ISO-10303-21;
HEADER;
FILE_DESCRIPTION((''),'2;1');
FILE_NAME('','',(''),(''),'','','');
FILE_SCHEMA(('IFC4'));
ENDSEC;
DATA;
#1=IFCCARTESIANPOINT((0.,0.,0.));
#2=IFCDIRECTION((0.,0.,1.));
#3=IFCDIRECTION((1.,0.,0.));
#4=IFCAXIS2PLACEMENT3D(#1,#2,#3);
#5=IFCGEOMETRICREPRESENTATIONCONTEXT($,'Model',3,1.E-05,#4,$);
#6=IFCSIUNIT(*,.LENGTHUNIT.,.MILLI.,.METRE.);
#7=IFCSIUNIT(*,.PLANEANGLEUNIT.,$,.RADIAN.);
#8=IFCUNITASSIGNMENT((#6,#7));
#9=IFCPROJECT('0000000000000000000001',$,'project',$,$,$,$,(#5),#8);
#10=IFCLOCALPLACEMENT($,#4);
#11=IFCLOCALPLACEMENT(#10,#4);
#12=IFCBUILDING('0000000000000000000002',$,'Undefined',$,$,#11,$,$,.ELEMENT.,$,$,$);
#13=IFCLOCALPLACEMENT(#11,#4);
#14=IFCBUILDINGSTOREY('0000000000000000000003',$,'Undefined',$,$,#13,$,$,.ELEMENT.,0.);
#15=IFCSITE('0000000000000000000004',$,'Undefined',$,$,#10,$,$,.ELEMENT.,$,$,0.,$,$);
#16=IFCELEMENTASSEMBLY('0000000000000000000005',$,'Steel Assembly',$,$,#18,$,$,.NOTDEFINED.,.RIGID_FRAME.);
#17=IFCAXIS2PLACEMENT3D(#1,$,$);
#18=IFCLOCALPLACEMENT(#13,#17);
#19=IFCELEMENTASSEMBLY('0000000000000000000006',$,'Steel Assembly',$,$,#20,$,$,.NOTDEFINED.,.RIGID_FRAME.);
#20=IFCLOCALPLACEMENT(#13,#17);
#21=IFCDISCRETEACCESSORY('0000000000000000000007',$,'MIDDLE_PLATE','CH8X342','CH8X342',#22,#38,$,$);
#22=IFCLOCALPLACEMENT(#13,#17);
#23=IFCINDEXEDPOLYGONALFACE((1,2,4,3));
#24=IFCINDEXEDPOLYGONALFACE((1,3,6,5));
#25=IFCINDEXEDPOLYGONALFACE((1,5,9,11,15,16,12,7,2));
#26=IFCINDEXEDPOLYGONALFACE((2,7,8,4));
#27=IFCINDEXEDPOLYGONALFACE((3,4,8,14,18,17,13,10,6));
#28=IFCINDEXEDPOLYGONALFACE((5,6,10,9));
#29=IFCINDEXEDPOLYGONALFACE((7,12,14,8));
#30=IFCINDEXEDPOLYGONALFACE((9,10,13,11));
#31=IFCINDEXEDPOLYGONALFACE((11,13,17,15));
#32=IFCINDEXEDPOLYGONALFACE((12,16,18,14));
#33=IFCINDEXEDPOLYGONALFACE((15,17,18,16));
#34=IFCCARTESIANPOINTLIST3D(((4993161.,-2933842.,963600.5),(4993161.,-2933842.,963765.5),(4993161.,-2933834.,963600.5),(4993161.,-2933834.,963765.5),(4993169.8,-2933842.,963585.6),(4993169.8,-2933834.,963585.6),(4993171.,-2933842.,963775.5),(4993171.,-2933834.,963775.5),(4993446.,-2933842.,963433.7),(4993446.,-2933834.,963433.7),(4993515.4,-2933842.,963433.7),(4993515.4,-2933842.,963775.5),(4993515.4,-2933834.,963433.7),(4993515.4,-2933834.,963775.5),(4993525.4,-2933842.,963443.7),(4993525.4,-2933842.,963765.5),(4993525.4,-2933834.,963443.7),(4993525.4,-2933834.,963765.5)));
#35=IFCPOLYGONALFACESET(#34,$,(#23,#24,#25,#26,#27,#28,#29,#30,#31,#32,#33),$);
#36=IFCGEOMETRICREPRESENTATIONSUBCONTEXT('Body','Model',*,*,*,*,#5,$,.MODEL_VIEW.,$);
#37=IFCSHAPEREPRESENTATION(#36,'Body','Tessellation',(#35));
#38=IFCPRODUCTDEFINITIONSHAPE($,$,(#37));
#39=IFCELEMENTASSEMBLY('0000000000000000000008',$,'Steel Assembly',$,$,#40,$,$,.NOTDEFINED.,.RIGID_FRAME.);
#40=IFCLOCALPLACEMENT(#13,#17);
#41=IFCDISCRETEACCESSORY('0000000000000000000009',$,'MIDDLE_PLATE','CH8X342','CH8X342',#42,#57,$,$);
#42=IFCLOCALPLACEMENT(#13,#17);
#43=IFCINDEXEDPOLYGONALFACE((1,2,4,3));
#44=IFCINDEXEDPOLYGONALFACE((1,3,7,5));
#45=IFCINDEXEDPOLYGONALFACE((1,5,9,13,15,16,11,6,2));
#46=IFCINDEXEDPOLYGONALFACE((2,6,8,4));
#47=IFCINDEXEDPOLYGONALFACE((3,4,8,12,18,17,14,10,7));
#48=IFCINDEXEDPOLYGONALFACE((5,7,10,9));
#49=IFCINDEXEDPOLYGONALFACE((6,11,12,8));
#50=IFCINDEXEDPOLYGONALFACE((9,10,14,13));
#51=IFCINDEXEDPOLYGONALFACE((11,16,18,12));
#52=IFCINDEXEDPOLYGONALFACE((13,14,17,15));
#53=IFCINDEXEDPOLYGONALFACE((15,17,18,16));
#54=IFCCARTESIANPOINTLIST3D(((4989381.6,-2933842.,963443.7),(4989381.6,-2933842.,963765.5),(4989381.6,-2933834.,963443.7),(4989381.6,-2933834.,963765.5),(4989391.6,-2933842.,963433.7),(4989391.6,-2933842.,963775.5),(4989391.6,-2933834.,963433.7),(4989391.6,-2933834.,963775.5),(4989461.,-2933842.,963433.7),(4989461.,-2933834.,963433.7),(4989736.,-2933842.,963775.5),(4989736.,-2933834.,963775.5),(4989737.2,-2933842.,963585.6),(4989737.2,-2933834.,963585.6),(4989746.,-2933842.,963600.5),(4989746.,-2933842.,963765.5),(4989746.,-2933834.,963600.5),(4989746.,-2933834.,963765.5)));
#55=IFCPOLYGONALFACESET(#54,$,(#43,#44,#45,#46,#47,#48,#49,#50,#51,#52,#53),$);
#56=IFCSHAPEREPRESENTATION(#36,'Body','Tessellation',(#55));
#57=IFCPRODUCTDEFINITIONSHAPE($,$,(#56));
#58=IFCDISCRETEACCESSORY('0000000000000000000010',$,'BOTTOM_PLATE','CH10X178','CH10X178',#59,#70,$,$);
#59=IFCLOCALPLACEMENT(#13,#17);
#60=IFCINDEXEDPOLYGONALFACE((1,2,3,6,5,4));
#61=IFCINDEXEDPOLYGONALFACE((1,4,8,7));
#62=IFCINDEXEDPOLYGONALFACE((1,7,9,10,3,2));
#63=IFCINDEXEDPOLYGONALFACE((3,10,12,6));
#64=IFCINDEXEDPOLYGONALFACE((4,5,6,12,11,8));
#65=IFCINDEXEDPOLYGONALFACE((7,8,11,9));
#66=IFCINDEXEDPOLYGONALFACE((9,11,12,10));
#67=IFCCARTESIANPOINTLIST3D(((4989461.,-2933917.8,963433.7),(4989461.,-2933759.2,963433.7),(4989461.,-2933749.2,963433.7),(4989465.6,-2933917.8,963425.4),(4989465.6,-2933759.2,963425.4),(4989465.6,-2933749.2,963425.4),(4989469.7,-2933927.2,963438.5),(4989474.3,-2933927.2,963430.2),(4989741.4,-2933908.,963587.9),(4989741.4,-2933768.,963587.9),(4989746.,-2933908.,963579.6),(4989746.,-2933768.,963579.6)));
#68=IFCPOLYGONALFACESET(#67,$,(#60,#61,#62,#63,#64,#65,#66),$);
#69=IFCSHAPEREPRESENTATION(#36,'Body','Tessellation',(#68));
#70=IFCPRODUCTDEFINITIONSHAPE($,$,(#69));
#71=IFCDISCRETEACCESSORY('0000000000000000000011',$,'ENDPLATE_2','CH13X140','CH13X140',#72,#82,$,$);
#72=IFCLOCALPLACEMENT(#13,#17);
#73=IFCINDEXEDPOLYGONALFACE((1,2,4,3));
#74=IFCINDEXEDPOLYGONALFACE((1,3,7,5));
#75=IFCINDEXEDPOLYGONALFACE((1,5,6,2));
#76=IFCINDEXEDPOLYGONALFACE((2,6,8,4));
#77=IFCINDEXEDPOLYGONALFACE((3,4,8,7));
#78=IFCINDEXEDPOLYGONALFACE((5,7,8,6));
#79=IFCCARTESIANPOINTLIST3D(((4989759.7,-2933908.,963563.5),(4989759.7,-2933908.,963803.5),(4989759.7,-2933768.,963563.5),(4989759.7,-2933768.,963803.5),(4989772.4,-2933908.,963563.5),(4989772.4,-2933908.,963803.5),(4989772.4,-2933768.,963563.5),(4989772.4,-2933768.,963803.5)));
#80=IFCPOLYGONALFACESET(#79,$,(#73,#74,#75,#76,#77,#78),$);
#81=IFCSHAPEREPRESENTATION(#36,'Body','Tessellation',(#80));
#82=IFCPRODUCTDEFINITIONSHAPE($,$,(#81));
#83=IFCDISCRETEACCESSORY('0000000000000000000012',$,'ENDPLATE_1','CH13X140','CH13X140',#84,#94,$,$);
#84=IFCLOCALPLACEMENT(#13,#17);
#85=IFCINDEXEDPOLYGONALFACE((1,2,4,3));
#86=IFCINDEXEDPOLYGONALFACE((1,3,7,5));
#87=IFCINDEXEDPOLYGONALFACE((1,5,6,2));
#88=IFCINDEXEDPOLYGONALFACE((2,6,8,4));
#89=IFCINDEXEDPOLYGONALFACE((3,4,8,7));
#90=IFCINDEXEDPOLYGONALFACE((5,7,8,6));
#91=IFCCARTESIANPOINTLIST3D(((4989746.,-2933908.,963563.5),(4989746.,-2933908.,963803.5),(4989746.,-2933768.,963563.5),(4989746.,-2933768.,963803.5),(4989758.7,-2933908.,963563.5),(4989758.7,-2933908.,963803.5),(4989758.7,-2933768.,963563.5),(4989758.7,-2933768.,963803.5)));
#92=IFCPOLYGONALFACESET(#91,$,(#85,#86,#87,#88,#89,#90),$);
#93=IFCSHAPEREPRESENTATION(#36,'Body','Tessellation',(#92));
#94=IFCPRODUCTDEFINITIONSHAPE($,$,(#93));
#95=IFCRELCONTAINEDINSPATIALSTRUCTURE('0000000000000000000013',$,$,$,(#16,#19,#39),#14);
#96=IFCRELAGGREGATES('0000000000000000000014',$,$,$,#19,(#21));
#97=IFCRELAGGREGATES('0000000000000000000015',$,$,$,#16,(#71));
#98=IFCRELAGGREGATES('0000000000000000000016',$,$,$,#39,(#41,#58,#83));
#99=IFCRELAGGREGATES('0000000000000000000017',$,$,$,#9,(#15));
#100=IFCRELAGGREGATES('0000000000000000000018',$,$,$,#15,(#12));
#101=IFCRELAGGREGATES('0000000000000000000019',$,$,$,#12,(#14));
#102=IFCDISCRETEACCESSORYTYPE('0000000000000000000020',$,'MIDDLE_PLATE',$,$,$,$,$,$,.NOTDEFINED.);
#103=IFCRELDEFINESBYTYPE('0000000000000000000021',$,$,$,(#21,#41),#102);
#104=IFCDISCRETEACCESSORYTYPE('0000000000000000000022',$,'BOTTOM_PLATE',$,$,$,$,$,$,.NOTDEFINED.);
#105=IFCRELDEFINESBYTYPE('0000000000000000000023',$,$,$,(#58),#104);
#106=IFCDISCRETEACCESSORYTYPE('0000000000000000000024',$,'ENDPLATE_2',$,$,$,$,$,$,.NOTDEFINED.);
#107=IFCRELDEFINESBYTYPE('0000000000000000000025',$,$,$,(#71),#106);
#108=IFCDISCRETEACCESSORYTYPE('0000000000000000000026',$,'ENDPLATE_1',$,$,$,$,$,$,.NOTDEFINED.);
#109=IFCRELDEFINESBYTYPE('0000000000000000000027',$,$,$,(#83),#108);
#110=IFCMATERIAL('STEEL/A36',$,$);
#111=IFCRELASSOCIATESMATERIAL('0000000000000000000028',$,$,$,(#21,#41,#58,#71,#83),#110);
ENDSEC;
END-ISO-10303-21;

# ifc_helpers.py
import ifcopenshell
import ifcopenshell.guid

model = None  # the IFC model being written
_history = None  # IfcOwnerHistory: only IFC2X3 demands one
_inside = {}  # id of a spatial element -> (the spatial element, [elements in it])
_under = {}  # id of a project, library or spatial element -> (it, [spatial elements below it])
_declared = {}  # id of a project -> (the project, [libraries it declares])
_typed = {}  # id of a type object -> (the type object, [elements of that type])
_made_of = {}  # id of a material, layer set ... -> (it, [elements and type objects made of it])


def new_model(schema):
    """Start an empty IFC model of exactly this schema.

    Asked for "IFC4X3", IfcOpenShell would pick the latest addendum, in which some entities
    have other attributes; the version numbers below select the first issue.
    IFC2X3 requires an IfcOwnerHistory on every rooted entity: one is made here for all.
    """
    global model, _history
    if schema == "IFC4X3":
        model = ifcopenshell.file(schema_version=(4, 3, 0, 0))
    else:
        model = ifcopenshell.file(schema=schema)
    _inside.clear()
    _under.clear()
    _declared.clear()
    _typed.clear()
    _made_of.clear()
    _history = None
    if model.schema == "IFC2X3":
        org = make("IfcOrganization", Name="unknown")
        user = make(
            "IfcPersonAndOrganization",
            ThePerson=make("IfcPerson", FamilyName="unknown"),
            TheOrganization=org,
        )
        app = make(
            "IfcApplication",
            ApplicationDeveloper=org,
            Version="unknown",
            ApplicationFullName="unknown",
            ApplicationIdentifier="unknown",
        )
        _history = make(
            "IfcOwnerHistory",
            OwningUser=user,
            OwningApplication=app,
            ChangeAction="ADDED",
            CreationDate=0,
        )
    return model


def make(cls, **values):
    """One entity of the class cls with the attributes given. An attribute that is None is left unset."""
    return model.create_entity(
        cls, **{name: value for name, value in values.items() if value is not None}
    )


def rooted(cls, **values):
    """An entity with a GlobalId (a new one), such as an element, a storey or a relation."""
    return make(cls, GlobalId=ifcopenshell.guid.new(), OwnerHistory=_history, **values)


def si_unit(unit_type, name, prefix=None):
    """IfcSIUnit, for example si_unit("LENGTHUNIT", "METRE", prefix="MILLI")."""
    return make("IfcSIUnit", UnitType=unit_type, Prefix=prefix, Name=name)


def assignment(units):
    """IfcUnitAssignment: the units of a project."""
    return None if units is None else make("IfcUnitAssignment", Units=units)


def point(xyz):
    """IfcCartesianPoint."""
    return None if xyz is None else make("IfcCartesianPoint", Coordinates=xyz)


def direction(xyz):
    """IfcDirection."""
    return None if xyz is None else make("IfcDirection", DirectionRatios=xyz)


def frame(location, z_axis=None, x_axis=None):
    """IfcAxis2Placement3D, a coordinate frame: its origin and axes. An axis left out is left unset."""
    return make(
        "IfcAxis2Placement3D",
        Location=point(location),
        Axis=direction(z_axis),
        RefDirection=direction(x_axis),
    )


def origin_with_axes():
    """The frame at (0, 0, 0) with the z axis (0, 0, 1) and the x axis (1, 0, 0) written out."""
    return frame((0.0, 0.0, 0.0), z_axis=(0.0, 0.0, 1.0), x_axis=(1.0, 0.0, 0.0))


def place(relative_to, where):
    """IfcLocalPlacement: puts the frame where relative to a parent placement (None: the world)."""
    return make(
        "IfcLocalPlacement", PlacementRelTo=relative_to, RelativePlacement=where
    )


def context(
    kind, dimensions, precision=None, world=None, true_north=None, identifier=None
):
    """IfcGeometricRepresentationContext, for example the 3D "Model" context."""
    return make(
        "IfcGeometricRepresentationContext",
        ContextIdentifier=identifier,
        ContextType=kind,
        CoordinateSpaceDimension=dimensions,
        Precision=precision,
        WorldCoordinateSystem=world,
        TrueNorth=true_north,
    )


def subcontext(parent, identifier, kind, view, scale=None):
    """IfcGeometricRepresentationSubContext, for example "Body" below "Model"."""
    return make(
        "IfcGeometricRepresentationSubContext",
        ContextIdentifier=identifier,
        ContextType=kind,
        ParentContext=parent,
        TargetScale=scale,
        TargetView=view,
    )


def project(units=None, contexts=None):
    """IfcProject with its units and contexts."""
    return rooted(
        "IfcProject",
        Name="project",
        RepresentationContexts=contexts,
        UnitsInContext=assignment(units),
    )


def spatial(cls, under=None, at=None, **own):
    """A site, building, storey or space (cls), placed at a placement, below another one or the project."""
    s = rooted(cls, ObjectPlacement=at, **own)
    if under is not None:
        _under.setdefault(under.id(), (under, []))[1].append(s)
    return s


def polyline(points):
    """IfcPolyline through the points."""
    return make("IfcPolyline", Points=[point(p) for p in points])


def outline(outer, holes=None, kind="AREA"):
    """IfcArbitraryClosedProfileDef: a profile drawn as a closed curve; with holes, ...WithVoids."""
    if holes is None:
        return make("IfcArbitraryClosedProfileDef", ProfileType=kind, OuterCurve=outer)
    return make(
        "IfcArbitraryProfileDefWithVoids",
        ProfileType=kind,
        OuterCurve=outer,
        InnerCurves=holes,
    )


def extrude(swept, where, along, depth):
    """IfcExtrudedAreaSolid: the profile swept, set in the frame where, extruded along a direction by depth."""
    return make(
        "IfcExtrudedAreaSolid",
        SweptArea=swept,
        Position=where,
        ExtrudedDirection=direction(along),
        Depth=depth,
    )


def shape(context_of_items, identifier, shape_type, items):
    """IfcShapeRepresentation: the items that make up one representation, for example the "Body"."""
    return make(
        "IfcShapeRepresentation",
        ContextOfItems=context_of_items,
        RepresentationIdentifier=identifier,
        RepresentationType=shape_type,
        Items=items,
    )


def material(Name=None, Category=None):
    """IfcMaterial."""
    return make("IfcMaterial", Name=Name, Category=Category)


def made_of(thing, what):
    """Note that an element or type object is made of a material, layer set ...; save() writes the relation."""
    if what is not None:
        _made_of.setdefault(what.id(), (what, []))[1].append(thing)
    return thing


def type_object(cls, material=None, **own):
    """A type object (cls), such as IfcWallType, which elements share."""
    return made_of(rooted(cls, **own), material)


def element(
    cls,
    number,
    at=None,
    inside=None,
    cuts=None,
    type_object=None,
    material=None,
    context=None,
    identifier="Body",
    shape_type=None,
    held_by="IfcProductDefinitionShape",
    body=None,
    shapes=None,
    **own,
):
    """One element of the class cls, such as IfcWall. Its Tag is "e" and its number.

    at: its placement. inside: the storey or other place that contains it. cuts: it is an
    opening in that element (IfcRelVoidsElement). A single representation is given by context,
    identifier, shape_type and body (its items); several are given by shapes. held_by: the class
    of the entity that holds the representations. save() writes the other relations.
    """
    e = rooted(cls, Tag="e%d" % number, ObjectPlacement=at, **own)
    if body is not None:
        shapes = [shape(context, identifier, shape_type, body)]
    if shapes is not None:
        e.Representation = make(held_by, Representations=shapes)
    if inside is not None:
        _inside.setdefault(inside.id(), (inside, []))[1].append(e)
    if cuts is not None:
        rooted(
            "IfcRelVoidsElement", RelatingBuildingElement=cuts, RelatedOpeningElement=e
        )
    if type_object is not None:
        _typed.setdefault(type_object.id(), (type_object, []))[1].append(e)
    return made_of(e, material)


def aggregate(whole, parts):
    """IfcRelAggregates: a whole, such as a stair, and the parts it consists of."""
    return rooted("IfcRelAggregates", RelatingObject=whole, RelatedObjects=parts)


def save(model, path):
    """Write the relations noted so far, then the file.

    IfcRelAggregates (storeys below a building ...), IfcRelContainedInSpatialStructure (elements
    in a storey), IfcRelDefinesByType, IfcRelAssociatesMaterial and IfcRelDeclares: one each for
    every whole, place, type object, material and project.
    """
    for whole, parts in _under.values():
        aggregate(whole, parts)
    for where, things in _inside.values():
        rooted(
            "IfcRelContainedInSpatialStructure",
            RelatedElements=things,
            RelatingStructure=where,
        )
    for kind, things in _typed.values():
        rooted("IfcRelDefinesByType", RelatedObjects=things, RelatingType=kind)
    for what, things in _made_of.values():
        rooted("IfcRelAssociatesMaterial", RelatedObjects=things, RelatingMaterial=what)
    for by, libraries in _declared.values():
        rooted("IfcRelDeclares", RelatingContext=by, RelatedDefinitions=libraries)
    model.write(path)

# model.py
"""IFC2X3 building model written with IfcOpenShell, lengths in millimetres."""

from ifc_helpers import new_model, si_unit, frame, origin_with_axes, place, context, subcontext, project, spatial, polyline, outline, extrude, material, type_object, element, aggregate, save


model = new_model("IFC2X3")

# Units and contexts
model_context = context("Model", 3, precision=1e-05, world=origin_with_axes())
body_context = subcontext(model_context, "Body", "Model", "MODEL_VIEW")
ifc_project = project(units=[si_unit("LENGTHUNIT", "METRE", prefix="MILLI"), si_unit("PLANEANGLEUNIT", "RADIAN")], contexts=[model_context])

# Site, building, storey
site_placement = place(None, origin_with_axes())
site = spatial("IfcSite", under=ifc_project, at=site_placement, Name="Undefined", CompositionType="ELEMENT", RefElevation=0.0)
building_placement = place(site_placement, origin_with_axes())
building = spatial("IfcBuilding", under=site, at=building_placement, Name="Undefined", CompositionType="ELEMENT")
storey_placement = place(building_placement, origin_with_axes())
storey = spatial("IfcBuildingStorey", under=building, at=storey_placement, Name="Undefined", CompositionType="ELEMENT", Elevation=0.0)

# Element assembly
assembly_1_placement = place(storey_placement, origin_with_axes())
assembly_1 = element("IfcElementAssembly", 1, at=assembly_1_placement, inside=storey, Name="Steel Assembly", AssemblyPlace="NOTDEFINED", PredefinedType="RIGID_FRAME")

# Shared definitions
ifc_material_1 = material(Name="STEEL/A36")

# Element assembly, discrete accessory
assembly_2_placement = place(storey_placement, origin_with_axes())
assembly_2 = element("IfcElementAssembly", 2, at=assembly_2_placement, inside=storey, Name="Steel Assembly", AssemblyPlace="NOTDEFINED", PredefinedType="RIGID_FRAME")
discrete_accessory_type_1 = type_object("IfcDiscreteAccessoryType", Name="MIDDLE_PLATE")
discrete_accessory_1_placement = place(assembly_2_placement, frame((4993161.0, -2933838.0, 963775.5), z_axis=(0.0, 1.0, 0.0), x_axis=(1.0, 0.0, 0.0)))
discrete_accessory_1 = element("IfcDiscreteAccessory", 3, at=discrete_accessory_1_placement, type_object=discrete_accessory_type_1, material=ifc_material_1, Name="MIDDLE_PLATE", Description="CH8X342", ObjectType="CH8X342", context=body_context, shape_type="SweptSolid", body=[
    extrude(outline(polyline([(0.0, 10.0), (10.0, 0.0), (354.4, 0.0), (364.4, 10.0), (364.4, 331.8), (354.4, 341.8), (285.0, 341.8), (8.8, 189.9), (0.0, 175.0), (0.0, 10.0)])), frame((0.0, 0.0, -4.0), z_axis=(0.0, 0.0, 1.0), x_axis=(1.0, 0.0, 0.0)), (0.0, 0.0, 1.0), 8.0),
])
aggregate(assembly_2, [discrete_accessory_1])

# Element assembly, discrete accessories
assembly_3_placement = place(storey_placement, origin_with_axes())
assembly_3 = element("IfcElementAssembly", 4, at=assembly_3_placement, inside=storey, Name="Steel Assembly", AssemblyPlace="NOTDEFINED", PredefinedType="RIGID_FRAME")
discrete_accessory_2_placement = place(assembly_3_placement, frame((4989746.0, -2933838.0, 963775.5), z_axis=(0.0, -1.0, 0.0), x_axis=(-1.0, 0.0, 0.0)))
discrete_accessory_2 = element("IfcDiscreteAccessory", 5, at=discrete_accessory_2_placement, type_object=discrete_accessory_type_1, material=ifc_material_1, Name="MIDDLE_PLATE", Description="CH8X342", ObjectType="CH8X342", context=body_context, shape_type="SweptSolid", body=[
    extrude(outline(polyline([(0.0, 10.0), (10.0, 0.0), (354.4, 0.0), (364.4, 10.0), (364.4, 331.8), (354.4, 341.8), (285.0, 341.8), (8.8, 189.9), (0.0, 175.0), (0.0, 10.0)])), frame((0.0, 0.0, -4.0), z_axis=(0.0, 0.0, 1.0), x_axis=(1.0, 0.0, 0.0)), (0.0, 0.0, 1.0), 8.0),
])
discrete_accessory_type_2 = type_object("IfcDiscreteAccessoryType", Name="BOTTOM_PLATE")
discrete_accessory_3_placement = place(assembly_3_placement, frame((4989463.3, -2933749.2, 963429.6), z_axis=(-0.481908, 0.0, 0.876222), x_axis=(0.0, -1.0, 0.0)))
discrete_accessory_3 = element("IfcDiscreteAccessory", 6, at=discrete_accessory_3_placement, type_object=discrete_accessory_type_2, material=ifc_material_1, Name="BOTTOM_PLATE", Description="CH10X178", ObjectType="CH10X178", context=body_context, shape_type="SweptSolid", body=[
    extrude(outline(polyline([(0.0, 0.0), (10.0, 0.0), (168.6, 0.0), (178.0, 10.0), (158.8, 320.0), (18.8, 320.0), (0.0, 0.0)])), frame((0.0, 0.0, -4.8), z_axis=(0.0, 0.0, 1.0), x_axis=(1.0, 0.0, 0.0)), (0.0, 0.0, 1.0), 9.5),
])

# Discrete accessories
discrete_accessory_type_3 = type_object("IfcDiscreteAccessoryType", Name="ENDPLATE_2")
discrete_accessory_4_placement = place(assembly_1_placement, frame((4989766.0, -2933768.0, 963563.5), z_axis=(1.0, 0.0, 0.0), x_axis=(0.0, 0.0, 1.0)))
discrete_accessory_4 = element("IfcDiscreteAccessory", 7, at=discrete_accessory_4_placement, type_object=discrete_accessory_type_3, material=ifc_material_1, Name="ENDPLATE_2", Description="CH13X140", ObjectType="CH13X140", context=body_context, shape_type="SweptSolid", body=[
    extrude(outline(polyline([(0.0, 0.0), (240.0, 0.0), (240.0, 140.0), (0.0, 140.0), (0.0, 0.0)])), frame((0.0, 0.0, -6.3), z_axis=(0.0, 0.0, 1.0), x_axis=(1.0, 0.0, 0.0)), (0.0, 0.0, 1.0), 12.7),
])
discrete_accessory_type_4 = type_object("IfcDiscreteAccessoryType", Name="ENDPLATE_1")
discrete_accessory_5_placement = place(assembly_3_placement, frame((4989752.3, -2933768.0, 963563.5), z_axis=(1.0, 0.0, 0.0), x_axis=(0.0, 0.0, 1.0)))
discrete_accessory_5 = element("IfcDiscreteAccessory", 8, at=discrete_accessory_5_placement, type_object=discrete_accessory_type_4, material=ifc_material_1, Name="ENDPLATE_1", Description="CH13X140", ObjectType="CH13X140", context=body_context, shape_type="SweptSolid", body=[
    extrude(outline(polyline([(0.0, 0.0), (240.0, 0.0), (240.0, 140.0), (0.0, 140.0), (0.0, 0.0)])), frame((0.0, 0.0, -6.3), z_axis=(0.0, 0.0, 1.0), x_axis=(1.0, 0.0, 0.0)), (0.0, 0.0, 1.0), 12.7),
])
aggregate(assembly_1, [discrete_accessory_4])
aggregate(assembly_3, [discrete_accessory_2, discrete_accessory_3, discrete_accessory_5])

save(model, "model.ifc")
